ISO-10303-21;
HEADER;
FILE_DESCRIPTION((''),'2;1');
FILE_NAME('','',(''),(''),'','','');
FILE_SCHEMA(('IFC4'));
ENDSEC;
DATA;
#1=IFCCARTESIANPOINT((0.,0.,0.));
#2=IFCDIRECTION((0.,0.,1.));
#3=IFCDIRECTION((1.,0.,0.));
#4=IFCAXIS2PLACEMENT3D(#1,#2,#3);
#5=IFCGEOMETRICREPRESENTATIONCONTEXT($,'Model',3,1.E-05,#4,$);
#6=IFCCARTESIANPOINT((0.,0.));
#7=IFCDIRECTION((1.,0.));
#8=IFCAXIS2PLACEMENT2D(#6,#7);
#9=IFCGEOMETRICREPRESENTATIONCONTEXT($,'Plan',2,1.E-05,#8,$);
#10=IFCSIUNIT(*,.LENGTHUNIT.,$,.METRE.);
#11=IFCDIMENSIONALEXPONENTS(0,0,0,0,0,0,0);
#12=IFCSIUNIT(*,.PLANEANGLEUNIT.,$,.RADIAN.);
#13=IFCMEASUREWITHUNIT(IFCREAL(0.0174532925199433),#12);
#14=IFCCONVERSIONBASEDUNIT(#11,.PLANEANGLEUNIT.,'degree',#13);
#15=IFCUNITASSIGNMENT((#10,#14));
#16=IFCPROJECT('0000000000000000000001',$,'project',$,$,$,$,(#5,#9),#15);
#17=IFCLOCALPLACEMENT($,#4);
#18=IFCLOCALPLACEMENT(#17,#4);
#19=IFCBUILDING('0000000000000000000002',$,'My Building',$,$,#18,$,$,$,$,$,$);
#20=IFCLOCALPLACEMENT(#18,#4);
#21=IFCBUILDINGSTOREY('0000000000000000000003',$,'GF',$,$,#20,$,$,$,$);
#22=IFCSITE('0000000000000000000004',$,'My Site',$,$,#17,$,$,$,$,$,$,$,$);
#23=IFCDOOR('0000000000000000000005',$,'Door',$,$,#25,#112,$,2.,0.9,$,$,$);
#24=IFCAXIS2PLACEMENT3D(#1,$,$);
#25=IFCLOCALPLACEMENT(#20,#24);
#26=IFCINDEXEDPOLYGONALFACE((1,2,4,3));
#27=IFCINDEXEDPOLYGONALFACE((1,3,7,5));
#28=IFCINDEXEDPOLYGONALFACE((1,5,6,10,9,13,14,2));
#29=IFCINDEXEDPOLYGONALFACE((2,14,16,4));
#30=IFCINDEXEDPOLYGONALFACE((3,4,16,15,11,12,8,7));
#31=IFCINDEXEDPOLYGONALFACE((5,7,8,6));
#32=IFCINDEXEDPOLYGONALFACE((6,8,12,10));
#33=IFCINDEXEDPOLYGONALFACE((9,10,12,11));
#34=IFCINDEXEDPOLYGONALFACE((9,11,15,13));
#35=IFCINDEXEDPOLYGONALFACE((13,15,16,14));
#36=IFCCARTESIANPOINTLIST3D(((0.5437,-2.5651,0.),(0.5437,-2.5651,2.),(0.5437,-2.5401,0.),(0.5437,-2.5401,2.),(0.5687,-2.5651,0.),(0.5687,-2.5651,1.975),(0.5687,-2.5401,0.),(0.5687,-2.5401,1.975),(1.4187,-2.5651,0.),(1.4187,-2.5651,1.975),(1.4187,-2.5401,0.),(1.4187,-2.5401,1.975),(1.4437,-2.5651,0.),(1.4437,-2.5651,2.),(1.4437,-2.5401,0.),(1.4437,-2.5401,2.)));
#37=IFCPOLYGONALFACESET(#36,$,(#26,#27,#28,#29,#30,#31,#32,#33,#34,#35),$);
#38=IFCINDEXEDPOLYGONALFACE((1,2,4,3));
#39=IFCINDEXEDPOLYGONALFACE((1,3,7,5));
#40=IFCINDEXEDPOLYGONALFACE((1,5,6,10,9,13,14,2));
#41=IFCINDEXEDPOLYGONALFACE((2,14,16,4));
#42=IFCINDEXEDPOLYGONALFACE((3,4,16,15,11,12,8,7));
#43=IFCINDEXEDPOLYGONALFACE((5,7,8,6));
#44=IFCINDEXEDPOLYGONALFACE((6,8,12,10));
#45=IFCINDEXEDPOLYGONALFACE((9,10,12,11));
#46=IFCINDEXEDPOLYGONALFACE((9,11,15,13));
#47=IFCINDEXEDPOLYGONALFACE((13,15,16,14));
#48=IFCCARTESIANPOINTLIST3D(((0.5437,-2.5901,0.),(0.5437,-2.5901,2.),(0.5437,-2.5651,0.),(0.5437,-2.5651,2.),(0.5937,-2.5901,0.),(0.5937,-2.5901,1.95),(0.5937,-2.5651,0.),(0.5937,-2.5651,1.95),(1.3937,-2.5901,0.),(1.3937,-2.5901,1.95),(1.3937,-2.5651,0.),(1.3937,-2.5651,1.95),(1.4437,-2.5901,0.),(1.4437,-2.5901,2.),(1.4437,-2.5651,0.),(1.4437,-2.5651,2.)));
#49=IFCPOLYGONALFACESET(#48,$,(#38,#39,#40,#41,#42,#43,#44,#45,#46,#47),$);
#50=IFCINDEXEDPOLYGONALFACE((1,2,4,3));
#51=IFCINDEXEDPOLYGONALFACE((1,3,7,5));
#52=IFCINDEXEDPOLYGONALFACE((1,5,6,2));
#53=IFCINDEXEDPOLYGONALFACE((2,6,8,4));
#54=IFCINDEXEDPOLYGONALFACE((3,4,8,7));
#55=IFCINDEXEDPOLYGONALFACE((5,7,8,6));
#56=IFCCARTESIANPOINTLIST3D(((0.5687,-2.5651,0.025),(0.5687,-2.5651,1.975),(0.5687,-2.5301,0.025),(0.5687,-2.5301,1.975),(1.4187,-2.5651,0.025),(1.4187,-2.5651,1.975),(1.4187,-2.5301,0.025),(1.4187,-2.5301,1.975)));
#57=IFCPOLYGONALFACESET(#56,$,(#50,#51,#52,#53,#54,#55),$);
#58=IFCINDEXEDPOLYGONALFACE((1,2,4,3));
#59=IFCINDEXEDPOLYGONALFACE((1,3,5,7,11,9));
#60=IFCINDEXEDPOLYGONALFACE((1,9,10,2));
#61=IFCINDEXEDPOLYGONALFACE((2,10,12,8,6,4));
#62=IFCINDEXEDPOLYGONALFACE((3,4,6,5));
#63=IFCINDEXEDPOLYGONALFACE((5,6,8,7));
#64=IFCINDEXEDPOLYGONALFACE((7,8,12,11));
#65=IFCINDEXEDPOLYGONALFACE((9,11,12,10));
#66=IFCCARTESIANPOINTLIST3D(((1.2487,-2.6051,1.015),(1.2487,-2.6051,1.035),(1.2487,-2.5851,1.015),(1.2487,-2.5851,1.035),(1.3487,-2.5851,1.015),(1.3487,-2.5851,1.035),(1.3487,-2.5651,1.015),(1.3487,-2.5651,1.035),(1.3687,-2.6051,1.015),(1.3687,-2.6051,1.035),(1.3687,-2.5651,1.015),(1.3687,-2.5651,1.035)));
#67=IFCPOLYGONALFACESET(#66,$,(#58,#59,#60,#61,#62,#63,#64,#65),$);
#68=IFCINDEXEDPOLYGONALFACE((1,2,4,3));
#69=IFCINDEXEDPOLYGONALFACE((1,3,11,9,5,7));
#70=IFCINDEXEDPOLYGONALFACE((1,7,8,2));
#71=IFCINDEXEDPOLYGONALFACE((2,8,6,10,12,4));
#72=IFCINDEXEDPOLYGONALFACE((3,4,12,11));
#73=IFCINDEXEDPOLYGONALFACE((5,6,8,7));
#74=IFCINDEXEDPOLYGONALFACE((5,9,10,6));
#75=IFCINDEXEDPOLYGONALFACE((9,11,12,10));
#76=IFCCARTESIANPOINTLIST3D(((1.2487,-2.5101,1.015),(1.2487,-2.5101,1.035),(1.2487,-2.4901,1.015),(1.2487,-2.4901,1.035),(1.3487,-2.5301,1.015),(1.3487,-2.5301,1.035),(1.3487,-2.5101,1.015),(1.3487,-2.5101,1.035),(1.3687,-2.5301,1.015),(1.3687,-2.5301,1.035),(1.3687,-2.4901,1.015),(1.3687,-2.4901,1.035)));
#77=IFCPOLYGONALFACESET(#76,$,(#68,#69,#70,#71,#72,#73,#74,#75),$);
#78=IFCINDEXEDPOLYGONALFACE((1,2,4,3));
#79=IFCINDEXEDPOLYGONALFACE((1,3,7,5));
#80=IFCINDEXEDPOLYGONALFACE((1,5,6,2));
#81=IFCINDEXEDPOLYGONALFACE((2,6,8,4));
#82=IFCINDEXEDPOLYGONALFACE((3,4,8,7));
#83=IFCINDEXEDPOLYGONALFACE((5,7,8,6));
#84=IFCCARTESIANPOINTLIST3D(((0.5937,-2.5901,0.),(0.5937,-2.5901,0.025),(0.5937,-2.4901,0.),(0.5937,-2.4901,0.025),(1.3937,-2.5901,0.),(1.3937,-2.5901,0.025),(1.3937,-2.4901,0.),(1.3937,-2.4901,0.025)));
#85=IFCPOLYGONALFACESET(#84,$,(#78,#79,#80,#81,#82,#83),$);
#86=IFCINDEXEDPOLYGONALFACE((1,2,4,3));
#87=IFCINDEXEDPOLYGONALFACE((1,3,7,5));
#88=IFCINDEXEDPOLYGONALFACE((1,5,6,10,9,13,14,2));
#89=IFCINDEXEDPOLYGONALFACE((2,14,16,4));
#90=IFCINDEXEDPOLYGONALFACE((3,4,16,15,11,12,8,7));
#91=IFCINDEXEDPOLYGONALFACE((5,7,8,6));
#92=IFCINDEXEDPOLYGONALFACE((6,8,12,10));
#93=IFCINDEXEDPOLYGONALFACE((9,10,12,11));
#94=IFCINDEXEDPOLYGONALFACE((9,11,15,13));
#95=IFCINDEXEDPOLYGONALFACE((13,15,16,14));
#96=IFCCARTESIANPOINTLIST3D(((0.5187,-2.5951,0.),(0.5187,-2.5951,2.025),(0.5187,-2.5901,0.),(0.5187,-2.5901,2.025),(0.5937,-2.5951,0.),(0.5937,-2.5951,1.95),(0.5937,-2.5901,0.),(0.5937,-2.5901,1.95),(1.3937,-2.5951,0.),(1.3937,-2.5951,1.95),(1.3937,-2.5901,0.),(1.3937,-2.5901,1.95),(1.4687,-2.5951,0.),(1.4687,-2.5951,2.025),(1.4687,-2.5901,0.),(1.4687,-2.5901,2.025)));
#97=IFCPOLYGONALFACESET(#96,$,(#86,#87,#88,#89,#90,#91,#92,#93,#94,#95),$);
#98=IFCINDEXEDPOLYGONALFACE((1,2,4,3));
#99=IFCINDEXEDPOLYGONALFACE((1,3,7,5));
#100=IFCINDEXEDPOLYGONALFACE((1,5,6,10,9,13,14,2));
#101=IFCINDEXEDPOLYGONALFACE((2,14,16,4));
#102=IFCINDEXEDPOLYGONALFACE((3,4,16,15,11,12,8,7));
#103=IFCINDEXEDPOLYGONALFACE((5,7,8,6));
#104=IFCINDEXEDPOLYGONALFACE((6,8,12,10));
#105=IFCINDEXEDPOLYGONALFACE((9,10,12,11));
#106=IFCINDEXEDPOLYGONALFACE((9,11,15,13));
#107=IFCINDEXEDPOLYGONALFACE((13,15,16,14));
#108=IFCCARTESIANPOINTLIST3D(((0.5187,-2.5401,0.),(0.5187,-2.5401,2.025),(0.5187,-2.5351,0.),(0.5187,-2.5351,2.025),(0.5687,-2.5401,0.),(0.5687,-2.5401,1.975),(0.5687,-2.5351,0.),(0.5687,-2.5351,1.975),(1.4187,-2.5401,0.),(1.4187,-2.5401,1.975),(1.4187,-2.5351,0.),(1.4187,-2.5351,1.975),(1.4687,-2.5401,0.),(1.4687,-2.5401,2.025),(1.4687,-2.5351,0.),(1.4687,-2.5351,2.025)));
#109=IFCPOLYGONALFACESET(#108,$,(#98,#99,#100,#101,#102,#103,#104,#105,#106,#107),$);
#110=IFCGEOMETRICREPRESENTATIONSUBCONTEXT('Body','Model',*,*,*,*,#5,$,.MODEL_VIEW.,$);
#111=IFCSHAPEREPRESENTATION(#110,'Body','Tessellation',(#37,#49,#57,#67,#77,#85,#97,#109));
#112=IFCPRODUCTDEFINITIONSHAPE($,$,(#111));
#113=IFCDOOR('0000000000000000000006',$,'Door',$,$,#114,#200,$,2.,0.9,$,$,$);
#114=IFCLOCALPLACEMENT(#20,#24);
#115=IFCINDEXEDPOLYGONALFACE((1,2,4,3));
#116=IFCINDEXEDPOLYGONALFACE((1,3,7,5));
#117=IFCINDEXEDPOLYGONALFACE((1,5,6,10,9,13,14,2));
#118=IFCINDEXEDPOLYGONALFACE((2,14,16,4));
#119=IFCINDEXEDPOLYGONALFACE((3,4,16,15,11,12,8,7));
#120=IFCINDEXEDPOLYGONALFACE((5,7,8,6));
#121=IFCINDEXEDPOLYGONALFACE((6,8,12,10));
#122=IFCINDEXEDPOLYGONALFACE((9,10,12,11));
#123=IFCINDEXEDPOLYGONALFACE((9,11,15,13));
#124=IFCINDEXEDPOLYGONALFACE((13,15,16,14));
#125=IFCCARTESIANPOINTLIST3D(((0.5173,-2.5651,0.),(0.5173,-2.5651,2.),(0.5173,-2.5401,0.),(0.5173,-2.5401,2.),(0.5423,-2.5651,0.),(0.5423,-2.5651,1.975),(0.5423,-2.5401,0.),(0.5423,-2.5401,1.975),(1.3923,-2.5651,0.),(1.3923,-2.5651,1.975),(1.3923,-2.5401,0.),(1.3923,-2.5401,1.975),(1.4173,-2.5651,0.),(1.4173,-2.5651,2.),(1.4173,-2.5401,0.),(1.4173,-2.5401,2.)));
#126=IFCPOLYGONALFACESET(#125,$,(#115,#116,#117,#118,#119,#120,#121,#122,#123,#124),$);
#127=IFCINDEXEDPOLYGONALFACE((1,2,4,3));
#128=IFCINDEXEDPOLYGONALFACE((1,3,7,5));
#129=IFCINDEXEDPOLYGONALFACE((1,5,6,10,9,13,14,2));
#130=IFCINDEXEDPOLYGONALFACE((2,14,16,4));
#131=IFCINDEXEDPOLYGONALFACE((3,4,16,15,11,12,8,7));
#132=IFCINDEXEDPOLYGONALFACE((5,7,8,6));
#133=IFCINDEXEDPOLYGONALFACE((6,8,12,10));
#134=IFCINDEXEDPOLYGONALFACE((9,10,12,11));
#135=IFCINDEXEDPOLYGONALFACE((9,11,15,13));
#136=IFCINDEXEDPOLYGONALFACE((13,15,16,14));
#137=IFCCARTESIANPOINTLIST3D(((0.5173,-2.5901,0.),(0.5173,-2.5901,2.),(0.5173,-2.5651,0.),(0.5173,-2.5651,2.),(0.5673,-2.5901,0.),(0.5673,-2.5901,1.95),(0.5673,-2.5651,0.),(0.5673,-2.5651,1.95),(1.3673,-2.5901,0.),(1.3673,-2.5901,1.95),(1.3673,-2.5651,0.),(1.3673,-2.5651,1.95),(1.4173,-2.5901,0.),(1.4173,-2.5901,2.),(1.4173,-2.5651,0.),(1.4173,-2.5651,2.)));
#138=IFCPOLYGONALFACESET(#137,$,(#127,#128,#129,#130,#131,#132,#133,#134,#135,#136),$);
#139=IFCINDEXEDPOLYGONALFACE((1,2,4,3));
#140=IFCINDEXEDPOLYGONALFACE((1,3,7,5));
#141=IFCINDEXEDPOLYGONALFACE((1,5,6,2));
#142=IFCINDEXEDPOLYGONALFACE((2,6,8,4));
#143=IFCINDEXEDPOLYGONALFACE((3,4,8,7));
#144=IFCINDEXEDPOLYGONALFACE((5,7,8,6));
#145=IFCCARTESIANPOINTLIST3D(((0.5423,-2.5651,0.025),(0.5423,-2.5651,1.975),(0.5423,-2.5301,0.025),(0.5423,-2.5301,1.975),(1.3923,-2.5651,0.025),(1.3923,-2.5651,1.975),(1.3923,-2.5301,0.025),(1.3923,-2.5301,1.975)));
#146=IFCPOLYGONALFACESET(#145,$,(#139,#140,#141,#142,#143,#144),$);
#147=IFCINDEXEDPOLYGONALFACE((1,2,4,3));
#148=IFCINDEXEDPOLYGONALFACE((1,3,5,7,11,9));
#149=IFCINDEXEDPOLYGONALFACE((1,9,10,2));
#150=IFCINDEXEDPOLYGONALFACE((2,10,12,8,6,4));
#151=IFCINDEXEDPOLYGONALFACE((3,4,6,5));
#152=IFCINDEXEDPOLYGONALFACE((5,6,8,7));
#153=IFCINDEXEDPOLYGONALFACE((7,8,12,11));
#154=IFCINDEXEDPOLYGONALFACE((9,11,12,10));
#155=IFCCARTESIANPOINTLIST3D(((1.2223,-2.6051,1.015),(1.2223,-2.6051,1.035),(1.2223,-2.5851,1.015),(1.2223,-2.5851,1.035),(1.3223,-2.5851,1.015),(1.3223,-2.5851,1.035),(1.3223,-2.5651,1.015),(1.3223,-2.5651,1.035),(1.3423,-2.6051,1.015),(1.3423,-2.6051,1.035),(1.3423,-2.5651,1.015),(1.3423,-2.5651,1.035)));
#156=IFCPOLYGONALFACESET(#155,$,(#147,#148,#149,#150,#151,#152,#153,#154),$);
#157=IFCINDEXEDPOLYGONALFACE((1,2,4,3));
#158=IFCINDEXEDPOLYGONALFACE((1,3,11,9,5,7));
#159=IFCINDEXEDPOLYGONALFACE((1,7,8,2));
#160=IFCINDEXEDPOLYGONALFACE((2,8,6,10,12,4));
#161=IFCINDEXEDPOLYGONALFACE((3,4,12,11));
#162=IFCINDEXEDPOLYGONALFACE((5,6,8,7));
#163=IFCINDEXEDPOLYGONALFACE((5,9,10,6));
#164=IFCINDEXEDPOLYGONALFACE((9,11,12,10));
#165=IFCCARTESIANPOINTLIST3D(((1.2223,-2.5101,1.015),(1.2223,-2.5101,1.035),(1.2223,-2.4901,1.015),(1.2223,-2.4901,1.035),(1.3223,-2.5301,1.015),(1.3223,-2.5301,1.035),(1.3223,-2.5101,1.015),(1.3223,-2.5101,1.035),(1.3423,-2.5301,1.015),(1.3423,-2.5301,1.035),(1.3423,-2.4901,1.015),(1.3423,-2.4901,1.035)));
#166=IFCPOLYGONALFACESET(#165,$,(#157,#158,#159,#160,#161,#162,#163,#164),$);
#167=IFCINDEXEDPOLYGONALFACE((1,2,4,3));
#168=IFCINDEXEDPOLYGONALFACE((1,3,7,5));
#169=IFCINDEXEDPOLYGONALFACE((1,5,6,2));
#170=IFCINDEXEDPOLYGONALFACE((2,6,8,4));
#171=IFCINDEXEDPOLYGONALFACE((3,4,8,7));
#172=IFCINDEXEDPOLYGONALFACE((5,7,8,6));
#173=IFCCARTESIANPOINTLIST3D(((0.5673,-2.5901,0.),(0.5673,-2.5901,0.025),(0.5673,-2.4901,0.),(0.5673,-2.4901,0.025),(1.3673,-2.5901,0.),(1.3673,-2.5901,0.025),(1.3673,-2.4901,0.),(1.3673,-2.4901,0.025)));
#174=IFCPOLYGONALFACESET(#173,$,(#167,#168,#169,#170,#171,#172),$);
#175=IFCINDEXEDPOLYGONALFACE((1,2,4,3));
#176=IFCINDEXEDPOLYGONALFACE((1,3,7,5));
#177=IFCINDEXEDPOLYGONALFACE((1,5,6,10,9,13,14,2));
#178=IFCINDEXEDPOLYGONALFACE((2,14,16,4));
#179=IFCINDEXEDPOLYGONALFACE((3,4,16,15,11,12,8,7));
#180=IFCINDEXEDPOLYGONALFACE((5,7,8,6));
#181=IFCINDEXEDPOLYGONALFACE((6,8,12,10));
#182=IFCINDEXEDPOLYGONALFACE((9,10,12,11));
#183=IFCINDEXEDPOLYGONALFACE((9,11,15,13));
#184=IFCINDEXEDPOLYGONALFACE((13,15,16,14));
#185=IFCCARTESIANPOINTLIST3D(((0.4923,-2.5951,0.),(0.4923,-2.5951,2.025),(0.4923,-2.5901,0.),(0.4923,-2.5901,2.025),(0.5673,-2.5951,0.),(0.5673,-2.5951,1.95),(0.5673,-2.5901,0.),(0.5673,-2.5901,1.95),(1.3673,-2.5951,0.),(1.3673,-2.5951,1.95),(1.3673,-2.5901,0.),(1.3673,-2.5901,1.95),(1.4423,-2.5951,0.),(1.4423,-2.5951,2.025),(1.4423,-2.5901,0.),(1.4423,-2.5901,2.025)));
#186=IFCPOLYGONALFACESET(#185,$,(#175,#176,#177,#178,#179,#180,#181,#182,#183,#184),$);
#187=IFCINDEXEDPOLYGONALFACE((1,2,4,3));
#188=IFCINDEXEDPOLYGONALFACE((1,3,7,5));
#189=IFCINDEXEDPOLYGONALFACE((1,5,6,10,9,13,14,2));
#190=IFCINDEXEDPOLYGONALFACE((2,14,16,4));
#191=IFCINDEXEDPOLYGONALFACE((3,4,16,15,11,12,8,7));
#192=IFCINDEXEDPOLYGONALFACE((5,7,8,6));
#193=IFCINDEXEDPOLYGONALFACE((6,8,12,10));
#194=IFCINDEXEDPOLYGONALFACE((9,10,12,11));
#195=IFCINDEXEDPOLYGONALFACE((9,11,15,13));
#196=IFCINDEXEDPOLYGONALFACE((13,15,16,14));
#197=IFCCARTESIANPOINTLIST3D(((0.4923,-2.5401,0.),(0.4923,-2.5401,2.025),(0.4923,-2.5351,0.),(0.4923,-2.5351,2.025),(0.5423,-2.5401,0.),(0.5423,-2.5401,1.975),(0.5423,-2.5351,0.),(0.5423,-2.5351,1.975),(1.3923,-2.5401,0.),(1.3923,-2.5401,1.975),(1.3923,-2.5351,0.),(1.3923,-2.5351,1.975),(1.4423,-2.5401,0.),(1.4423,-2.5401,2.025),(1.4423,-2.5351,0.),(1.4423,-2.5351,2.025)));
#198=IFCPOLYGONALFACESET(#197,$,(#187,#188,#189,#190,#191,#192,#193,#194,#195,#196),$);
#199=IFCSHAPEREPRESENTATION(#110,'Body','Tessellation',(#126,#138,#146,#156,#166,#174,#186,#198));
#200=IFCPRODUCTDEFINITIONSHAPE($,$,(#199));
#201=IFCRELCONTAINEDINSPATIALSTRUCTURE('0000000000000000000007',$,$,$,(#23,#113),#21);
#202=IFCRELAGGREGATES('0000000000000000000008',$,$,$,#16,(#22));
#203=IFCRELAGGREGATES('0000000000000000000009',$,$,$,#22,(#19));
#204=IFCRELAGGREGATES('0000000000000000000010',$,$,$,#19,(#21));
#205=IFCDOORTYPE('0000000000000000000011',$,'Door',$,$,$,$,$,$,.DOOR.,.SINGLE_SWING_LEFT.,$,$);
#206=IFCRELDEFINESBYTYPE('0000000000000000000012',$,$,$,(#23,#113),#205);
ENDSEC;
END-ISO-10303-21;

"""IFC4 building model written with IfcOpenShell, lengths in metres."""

from ifc_helpers import new_model, entity, si_unit, converted_unit, frame, origin_with_axes, origin_2d_with_axis, place, context, subcontext, project, spatial, line, indexed_curve, outline, extrude, shape, source, transform, mapped, type_object, type_shapes, element, save


model = new_model("IFC4")

# Units and contexts
model_context = context("Model", 3, precision=1e-05, world=origin_with_axes())
plan_context = context("Plan", 2, precision=1e-05, world=origin_2d_with_axis())
body_context_1 = subcontext(model_context, "Body", "Model", "MODEL_VIEW")
body_context_2 = subcontext(plan_context, "Body", "Plan", "PLAN_VIEW")
ifc_project = project(units=[si_unit("LENGTHUNIT", "METRE"), converted_unit("PLANEANGLEUNIT", "degree", entity("IfcReal", 0.0174532925199433), si_unit("PLANEANGLEUNIT", "RADIAN"), dimensions=[0, 0, 0, 0, 0, 0, 0])], contexts=[model_context, plan_context])

# Site, building, storey
site_placement = place(None, origin_with_axes())
site = spatial("IfcSite", under=ifc_project, at=site_placement, Name="My Site")
building_placement = place(site_placement, origin_with_axes())
building = spatial("IfcBuilding", under=site, at=building_placement, Name="My Building")
storey_placement = place(building_placement, origin_with_axes())
storey = spatial("IfcBuildingStorey", under=building, at=storey_placement, Name="GF")

# Shared definitions
door_type = type_object("IfcDoorType", Name="Door", OperationType="SINGLE_SWING_LEFT", PredefinedType="DOOR")
shared_shape_1 = source(origin_with_axes(), body_context_1, "Body", "SweptSolid", [
    extrude(outline(indexed_curve([(0.0, 0.0), (0.0, 2.0), (0.9, 2.0), (0.9, 0.0), (0.875, 0.0), (0.875, 1.975), (0.025, 1.975), (0.025, 0.0)], segments=[line(1, 2, 3, 4, 5, 6, 7, 8, 1)])), frame((0.0, 0.025, 0.0), z_axis=(0.0, -1.0, 0.0), x_axis=(1.0, 0.0, 0.0)), (0.0, 0.0, -1.0), 0.025),
    extrude(outline(indexed_curve([(0.0, 0.0), (0.0, 2.0), (0.9, 2.0), (0.9, 0.0), (0.85, 0.0), (0.85, 1.95), (0.05, 1.95), (0.05, 0.0)], segments=[line(1, 2, 3, 4, 5, 6, 7, 8, 1)])), frame((0.0, 0.0, 0.0), z_axis=(0.0, -1.0, 0.0), x_axis=(1.0, 0.0, 0.0)), (0.0, 0.0, -1.0), 0.025),
    extrude(outline(indexed_curve([(0.0, 0.0), (0.85, 0.0), (0.85, 0.035), (0.0, 0.035)], segments=[line(1, 2, 3, 4, 1)])), frame((0.025, 0.025, 0.025), z_axis=(0.0, 0.0, 1.0), x_axis=(1.0, 0.0, 0.0)), (0.0, 0.0, 1.0), 1.95),
    extrude(outline(indexed_curve([(0.0, 0.0), (0.0, -0.04), (-0.12, -0.04), (-0.12, -0.02), (-0.02, -0.02), (-0.02, 0.0)], segments=[line(1, 2, 3, 4, 5, 6, 1)])), frame((0.825, 0.025, 1.015), z_axis=(0.0, 0.0, 1.0), x_axis=(1.0, 0.0, 0.0)), (0.0, 0.0, 1.0), 0.02),
    extrude(outline(indexed_curve([(0.0, 0.0), (0.0, 0.04), (-0.12, 0.04), (-0.12, 0.02), (-0.02, 0.02), (-0.02, 0.0)], segments=[line(1, 2, 3, 4, 5, 6, 1)])), frame((0.825, 0.06, 1.015), z_axis=(0.0, 0.0, 1.0), x_axis=(1.0, 0.0, 0.0)), (0.0, 0.0, 1.0), 0.02),
    extrude(outline(indexed_curve([(0.0, 0.0), (0.8, 0.0), (0.8, 0.1), (0.0, 0.1)], segments=[line(1, 2, 3, 4, 1)])), frame((0.05, 0.0, 0.0), z_axis=(0.0, 0.0, 1.0), x_axis=(1.0, 0.0, 0.0)), (0.0, 0.0, 1.0), 0.025),
    extrude(outline(indexed_curve([(0.0, 0.0), (0.0, 2.025), (0.95, 2.025), (0.95, 0.0), (0.875, 0.0), (0.875, 1.95), (0.075, 1.95), (0.075, 0.0)], segments=[line(1, 2, 3, 4, 5, 6, 7, 8, 1)])), frame((-0.025, -0.005, 0.0), z_axis=(0.0, -1.0, 0.0), x_axis=(1.0, 0.0, 0.0)), (0.0, 0.0, -1.0), 0.005),
    extrude(outline(indexed_curve([(0.0, 0.0), (0.0, 2.025), (0.95, 2.025), (0.95, 0.0), (0.9, 0.0), (0.9, 1.975), (0.05, 1.975), (0.05, 0.0)], segments=[line(1, 2, 3, 4, 5, 6, 7, 8, 1)])), frame((-0.025, 0.05, 0.0), z_axis=(0.0, -1.0, 0.0), x_axis=(1.0, 0.0, 0.0)), (0.0, 0.0, -1.0), 0.005),
])
shared_shape_2 = source(origin_with_axes(), body_context_2, "Body", "Curve2D", [
    entity("IfcIndexedPolyCurve", entity("IfcCartesianPointList2D", [[0.0, 0.0], [0.0, 0.05], [0.025, 0.05], [0.025, 0.025], [0.05, 0.025], [0.05, 0.0]]), [entity("IfcLineIndex", [1, 2, 3, 4, 5, 6, 1])]),
    entity("IfcIndexedPolyCurve", entity("IfcCartesianPointList2D", [[0.9, 0.0], [0.9, 0.05], [0.875, 0.05], [0.875, 0.025], [0.85, 0.025], [0.85, 0.0]]), [entity("IfcLineIndex", [1, 2, 3, 4, 5, 6, 1])]),
    entity("IfcTrimmedCurve", entity("IfcEllipse", entity("IfcAxis2Placement2D", entity("IfcCartesianPoint", [0.06, 0.05]), entity("IfcDirection", [1.0, 0.0])), 0.815, 0.85), [entity("IfcCartesianPoint", [0.875, 0.05])], [entity("IfcCartesianPoint", [0.06, 0.9])], True, "CARTESIAN"),
    entity("IfcIndexedPolyCurve", entity("IfcCartesianPointList2D", [[0.025, 0.05], [0.06, 0.05], [0.06, 0.9], [0.025, 0.9]]), [entity("IfcLineIndex", [1, 2, 3, 4, 1])]),
])
type_shapes(door_type, [shared_shape_1, shared_shape_2])

# Doors
for number, where, z_axis, x_axis, name in (
    (1, (0.5437, -2.5901, 0.0), (0.0, 0.0, 1.0), (1.0, 0.0, 0.0), "Door"),
    (2, (0.5173, -2.5901, 0.0), (0.0, 0.0, 1.0), (1.0, 0.0, 0.0), "Door"),
):
    element("IfcDoor", number, at=place(storey_placement, frame(where, z_axis=z_axis, x_axis=x_axis)), inside=storey, type_object=door_type, Name=name, OverallHeight=2.0, OverallWidth=0.9, shapes=[
        shape(body_context_1, "Body", "MappedRepresentation", [mapped(shared_shape_1, transform((0.0, 0.0, 0.0), x_axis=(1.0, 0.0, 0.0), y_axis=(0.0, 1.0, 0.0), z_axis=(0.0, 0.0, 1.0), scale=1.0))]),
        shape(body_context_2, "Body", "MappedRepresentation", [mapped(shared_shape_2, transform((0.0, 0.0, 0.0), x_axis=(1.0, 0.0, 0.0), y_axis=(0.0, 1.0, 0.0), z_axis=(0.0, 0.0, 1.0), scale=1.0))]),
    ])

save(model, "model.ifc")
